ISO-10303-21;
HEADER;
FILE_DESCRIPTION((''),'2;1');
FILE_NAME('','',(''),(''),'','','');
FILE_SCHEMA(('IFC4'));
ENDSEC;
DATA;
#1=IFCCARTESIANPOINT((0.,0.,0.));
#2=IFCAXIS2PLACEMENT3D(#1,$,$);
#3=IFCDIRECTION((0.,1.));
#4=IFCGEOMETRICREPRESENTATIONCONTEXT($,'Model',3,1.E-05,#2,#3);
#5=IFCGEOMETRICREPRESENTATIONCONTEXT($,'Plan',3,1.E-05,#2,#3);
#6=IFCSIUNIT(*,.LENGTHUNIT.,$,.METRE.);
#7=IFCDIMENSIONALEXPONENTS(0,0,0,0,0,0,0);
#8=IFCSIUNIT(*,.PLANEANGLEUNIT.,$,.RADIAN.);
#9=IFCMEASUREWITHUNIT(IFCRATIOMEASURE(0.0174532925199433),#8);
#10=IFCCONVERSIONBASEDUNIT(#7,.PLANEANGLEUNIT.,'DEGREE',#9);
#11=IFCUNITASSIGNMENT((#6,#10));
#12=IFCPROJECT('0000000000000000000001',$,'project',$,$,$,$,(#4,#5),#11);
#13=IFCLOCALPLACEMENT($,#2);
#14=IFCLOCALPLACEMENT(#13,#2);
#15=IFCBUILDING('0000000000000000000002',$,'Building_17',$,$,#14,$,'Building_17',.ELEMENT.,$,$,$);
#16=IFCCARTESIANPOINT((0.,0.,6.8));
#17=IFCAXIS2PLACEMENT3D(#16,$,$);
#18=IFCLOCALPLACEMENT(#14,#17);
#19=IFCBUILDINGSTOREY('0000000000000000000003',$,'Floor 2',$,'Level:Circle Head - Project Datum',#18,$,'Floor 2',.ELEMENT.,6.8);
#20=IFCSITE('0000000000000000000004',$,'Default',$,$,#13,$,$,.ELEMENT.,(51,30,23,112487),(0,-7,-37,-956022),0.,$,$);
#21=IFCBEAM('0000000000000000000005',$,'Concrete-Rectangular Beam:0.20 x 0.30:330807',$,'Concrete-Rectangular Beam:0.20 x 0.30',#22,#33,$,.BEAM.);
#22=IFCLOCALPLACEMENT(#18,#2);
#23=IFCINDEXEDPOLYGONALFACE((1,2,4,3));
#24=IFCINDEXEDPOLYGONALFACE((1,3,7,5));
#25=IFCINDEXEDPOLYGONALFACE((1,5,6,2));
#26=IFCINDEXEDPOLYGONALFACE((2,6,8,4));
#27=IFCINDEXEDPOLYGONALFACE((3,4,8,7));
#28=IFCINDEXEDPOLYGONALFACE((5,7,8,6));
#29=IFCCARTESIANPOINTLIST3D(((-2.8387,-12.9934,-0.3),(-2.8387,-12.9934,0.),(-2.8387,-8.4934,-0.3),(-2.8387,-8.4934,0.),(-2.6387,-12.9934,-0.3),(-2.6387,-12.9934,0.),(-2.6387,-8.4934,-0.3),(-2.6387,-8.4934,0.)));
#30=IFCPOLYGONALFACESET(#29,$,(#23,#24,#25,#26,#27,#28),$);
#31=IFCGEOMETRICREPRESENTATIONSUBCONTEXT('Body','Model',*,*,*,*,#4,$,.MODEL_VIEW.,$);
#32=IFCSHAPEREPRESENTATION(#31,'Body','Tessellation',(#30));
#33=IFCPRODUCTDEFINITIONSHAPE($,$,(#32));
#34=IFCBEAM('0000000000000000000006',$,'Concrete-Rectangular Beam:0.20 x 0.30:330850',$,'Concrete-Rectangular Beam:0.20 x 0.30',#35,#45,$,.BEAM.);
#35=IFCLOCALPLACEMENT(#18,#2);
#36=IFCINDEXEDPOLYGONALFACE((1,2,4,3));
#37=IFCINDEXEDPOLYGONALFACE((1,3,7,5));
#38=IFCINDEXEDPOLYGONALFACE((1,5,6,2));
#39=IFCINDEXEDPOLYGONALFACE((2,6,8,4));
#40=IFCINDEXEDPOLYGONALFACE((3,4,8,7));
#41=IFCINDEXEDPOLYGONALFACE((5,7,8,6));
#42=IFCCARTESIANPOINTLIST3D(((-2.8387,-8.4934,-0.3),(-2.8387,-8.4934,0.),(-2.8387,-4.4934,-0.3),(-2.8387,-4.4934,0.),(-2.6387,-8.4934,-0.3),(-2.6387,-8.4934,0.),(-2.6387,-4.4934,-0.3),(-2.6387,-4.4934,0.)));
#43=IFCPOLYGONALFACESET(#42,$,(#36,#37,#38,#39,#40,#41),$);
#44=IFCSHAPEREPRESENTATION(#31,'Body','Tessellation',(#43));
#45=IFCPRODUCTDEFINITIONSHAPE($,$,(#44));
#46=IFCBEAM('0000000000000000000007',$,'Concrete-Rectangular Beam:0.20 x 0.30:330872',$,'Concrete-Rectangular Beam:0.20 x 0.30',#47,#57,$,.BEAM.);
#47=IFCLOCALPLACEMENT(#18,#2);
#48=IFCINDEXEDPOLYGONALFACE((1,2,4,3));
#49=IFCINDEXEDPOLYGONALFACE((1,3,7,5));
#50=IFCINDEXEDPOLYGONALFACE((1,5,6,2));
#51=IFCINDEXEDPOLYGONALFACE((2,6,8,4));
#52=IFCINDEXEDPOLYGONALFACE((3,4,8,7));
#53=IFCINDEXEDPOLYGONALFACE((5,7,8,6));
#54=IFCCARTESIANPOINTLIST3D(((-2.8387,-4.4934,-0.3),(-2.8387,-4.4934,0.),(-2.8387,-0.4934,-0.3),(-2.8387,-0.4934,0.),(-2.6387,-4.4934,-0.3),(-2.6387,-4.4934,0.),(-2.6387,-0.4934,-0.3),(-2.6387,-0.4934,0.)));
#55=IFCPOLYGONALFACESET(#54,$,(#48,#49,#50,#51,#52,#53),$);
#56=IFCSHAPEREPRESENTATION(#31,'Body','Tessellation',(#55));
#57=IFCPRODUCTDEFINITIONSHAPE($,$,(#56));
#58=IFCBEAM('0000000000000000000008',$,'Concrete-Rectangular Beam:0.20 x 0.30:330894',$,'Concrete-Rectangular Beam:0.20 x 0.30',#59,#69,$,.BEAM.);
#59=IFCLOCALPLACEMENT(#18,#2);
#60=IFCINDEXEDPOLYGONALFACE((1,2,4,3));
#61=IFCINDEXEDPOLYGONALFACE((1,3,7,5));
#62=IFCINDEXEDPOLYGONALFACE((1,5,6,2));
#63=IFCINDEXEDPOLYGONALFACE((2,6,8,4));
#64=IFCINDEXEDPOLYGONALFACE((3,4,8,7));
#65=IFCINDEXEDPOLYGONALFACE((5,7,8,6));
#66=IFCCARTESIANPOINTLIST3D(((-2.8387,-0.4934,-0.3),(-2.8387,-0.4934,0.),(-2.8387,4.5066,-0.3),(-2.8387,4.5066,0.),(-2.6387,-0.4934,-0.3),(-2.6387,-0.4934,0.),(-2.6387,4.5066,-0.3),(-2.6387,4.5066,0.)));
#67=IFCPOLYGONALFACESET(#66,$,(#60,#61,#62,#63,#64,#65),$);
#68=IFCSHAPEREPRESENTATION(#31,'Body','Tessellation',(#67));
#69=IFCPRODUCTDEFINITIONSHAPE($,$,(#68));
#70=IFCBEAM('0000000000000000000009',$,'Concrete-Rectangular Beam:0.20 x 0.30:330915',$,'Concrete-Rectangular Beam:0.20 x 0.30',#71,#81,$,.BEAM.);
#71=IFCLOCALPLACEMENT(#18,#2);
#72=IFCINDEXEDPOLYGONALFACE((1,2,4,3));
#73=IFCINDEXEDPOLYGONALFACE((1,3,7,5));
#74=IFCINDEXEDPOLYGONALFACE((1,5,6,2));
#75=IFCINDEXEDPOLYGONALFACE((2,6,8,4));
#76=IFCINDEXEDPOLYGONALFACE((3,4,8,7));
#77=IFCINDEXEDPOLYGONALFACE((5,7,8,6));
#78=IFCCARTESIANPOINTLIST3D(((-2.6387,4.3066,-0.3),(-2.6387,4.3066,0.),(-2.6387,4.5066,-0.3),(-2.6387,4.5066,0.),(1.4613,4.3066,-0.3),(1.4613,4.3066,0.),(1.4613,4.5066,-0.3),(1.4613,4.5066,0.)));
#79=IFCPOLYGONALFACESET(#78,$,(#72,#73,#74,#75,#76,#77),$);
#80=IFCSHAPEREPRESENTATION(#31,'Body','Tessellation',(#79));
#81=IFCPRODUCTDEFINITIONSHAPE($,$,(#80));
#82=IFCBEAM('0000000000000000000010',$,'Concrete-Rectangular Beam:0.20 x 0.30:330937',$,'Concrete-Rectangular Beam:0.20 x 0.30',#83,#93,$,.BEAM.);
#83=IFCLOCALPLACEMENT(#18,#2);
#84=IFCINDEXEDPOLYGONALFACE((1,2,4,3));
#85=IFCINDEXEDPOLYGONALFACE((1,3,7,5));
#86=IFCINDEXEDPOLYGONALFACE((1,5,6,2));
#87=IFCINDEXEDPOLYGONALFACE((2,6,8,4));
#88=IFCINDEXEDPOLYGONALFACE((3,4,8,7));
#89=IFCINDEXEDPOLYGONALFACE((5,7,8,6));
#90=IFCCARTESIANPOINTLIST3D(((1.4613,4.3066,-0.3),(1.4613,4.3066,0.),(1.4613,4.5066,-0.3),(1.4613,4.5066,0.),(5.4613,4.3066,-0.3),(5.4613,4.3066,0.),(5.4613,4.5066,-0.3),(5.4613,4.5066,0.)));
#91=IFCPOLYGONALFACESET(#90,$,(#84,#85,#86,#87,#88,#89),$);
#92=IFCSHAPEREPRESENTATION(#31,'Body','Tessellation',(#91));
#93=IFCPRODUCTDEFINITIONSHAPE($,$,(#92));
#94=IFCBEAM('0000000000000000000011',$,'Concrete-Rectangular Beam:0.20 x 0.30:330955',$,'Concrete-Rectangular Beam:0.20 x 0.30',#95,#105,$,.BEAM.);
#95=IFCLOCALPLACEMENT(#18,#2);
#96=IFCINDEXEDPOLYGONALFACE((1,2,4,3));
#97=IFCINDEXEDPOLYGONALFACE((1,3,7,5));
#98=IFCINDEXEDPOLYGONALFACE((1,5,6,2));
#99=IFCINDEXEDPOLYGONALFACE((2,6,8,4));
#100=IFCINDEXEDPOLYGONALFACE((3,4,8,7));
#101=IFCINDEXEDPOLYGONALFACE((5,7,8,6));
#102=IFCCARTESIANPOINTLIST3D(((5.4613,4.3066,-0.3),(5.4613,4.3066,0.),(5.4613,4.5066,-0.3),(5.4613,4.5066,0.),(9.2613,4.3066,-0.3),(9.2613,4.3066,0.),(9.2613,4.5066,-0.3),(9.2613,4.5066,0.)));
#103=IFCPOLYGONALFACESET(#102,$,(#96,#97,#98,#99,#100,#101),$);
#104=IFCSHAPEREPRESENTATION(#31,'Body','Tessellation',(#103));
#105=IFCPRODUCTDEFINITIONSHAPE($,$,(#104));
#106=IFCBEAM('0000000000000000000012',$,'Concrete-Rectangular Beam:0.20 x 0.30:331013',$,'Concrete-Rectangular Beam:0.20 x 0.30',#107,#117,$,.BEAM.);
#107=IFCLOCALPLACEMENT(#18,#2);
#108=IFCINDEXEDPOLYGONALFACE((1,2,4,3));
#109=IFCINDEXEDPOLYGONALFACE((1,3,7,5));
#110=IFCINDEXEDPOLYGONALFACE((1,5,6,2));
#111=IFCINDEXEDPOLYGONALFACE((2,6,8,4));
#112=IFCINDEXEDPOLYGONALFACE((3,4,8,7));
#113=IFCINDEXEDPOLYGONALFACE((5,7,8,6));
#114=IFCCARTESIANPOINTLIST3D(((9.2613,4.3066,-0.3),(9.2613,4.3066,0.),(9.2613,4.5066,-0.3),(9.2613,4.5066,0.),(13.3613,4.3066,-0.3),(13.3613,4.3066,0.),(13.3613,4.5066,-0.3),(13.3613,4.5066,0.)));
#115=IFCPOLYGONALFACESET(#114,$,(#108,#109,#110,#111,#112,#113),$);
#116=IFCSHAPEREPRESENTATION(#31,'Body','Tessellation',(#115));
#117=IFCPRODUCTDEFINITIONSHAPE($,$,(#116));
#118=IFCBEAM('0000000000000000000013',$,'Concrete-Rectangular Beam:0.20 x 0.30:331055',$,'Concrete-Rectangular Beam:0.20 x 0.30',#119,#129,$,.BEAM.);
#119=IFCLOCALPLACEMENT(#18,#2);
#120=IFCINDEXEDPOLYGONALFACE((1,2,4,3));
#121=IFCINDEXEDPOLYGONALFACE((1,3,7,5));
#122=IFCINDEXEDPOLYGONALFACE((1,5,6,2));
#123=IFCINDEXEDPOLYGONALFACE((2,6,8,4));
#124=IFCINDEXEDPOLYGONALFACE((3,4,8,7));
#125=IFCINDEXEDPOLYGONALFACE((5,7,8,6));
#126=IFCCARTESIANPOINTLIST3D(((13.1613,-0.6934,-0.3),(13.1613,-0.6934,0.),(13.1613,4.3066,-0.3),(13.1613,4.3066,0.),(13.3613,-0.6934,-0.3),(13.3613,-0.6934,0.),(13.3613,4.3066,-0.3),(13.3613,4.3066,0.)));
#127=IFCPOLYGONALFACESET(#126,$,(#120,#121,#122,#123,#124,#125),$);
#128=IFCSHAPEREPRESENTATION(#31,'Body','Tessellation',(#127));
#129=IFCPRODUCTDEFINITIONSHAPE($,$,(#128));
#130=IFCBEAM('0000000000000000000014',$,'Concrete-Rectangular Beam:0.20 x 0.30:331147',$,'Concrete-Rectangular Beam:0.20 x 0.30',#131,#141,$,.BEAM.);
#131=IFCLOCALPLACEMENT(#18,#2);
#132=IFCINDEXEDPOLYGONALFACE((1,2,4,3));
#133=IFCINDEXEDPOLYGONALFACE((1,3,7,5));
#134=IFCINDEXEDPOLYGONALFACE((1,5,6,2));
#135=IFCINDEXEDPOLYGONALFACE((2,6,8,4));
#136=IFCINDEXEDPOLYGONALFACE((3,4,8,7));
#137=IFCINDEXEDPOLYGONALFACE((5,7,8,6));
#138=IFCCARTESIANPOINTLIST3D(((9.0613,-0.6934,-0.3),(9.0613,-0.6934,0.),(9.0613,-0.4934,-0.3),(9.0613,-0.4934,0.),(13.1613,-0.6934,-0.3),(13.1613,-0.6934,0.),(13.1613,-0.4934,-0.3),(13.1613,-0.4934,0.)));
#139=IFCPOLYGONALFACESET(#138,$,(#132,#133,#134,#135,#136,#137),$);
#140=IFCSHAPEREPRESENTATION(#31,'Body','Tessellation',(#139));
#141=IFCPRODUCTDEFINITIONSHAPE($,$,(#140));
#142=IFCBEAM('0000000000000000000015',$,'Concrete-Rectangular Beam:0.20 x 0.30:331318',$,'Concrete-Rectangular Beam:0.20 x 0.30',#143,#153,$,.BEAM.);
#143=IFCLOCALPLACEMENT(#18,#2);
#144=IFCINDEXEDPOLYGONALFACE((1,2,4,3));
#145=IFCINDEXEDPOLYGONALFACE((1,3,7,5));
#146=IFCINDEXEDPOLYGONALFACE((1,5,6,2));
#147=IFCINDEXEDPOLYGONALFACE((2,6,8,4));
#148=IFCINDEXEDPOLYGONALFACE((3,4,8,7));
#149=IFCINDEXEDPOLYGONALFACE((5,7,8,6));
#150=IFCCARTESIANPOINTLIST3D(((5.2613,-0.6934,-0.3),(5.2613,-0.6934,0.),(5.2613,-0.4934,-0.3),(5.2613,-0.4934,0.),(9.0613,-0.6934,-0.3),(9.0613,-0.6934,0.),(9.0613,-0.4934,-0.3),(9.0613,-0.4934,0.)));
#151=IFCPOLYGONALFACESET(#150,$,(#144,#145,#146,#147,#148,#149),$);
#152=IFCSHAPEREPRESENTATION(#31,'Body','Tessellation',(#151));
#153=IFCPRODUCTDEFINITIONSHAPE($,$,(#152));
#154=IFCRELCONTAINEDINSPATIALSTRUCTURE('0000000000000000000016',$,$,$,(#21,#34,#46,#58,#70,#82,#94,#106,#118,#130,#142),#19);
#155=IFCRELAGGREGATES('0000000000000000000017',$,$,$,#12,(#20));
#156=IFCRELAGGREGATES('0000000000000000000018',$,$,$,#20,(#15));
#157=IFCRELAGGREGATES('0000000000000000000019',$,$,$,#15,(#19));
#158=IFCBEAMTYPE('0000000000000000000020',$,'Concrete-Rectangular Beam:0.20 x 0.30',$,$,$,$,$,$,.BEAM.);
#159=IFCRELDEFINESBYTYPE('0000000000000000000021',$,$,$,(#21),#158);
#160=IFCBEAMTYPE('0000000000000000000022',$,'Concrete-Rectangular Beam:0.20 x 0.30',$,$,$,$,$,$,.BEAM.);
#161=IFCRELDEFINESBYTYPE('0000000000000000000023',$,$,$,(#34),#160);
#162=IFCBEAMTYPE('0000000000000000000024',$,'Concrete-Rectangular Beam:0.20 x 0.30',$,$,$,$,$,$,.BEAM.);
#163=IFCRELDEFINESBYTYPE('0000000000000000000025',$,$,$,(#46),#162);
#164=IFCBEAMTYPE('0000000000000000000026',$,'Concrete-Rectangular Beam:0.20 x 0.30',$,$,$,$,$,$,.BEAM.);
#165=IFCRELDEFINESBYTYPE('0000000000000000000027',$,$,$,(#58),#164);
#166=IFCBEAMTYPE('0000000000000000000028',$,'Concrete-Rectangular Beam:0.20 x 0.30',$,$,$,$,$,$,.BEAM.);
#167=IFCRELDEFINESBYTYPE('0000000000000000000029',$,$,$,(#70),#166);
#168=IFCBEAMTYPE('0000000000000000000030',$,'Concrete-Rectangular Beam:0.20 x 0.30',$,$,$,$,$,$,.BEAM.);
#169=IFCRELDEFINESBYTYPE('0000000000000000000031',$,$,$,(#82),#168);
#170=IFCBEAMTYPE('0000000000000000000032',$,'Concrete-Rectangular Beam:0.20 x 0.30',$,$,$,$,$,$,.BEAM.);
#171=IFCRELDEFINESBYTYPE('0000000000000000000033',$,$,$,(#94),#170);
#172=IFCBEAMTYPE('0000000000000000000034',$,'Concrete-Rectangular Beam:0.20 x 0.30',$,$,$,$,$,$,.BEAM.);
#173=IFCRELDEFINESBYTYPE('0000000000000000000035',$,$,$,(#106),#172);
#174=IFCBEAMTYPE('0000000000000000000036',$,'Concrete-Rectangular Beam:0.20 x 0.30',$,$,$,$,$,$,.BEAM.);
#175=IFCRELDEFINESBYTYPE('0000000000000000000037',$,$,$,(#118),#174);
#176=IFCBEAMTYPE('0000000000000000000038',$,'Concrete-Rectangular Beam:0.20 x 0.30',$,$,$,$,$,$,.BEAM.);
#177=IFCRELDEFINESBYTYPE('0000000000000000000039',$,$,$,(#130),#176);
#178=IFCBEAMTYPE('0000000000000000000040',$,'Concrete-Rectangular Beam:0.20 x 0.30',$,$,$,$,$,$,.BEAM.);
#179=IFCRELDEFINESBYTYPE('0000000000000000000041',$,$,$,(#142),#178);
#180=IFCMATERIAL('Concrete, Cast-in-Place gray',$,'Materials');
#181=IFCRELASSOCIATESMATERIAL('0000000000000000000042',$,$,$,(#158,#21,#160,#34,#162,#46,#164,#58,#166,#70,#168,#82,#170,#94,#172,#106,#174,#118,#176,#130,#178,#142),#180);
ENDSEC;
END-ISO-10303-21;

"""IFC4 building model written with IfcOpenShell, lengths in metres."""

from ifc_helpers import new_model, entity, si_unit, converted_unit, direction, frame, origin, place, context, subcontext, project, spatial, indexed_curve, outline, extrude, source, transform, mapped, material, type_object, type_shapes, element, save


model = new_model("IFC4")

# Units and contexts
model_context = context("Model", 3, precision=1e-05, world=origin(), true_north=direction((0.0, 1.0)))
plan_context = context("Plan", 3, precision=1e-05, world=origin(), true_north=direction((0.0, 1.0)))
body_context = subcontext(model_context, "Body", "Model", "MODEL_VIEW")
ifc_project = project(units=[si_unit("LENGTHUNIT", "METRE"), converted_unit("PLANEANGLEUNIT", "DEGREE", entity("IfcRatioMeasure", 0.0174532925199433), si_unit("PLANEANGLEUNIT", "RADIAN"), dimensions=[0, 0, 0, 0, 0, 0, 0])], contexts=[model_context, plan_context])

# Site, building, storey
site_placement = place(None, origin())
site = spatial("IfcSite", under=ifc_project, at=site_placement, Name="Default", CompositionType="ELEMENT", RefLatitude=(51, 30, 23, 112487), RefLongitude=(0, -7, -37, -956022), RefElevation=0.0)
building_placement = place(site_placement, origin())
building = spatial("IfcBuilding", under=site, at=building_placement, Name="Building_17", LongName="Building_17", CompositionType="ELEMENT")
storey_placement = place(building_placement, frame((0.0, 0.0, 6.8)))
storey = spatial("IfcBuildingStorey", under=building, at=storey_placement, Name="Floor 2", ObjectType="Level:Circle Head - Project Datum", LongName="Floor 2", CompositionType="ELEMENT", Elevation=6.8)

# Beams
ifc_material = material(Name="Concrete, Cast-in-Place gray", Category="Materials")
beam_type_1 = type_object("IfcBeamType", Name="Concrete-Rectangular Beam:0.20 x 0.30", PredefinedType="BEAM", material=ifc_material)
shared_shape_1 = source(origin(), body_context, "Body", "SweptSolid", [
    extrude(outline(indexed_curve([(-0.1, -0.15), (0.1, -0.15), (0.1, 0.15), (-0.1, 0.15), (-0.1, -0.15)], self_intersect=False)), frame((-2.7387, -12.9934, 6.65), z_axis=(0.0, 1.0, 0.0), x_axis=(-1.0, 0.0, 0.0)), (0.0, 0.0, 1.0), 4.5),
])
type_shapes(beam_type_1, [shared_shape_1])
beam_1_placement = place(storey_placement, frame((0.0, 0.0, -6.8)))
element("IfcBeam", 1, at=beam_1_placement, inside=storey, type_object=beam_type_1, material=ifc_material, Name="Concrete-Rectangular Beam:0.20 x 0.30:330807", ObjectType="Concrete-Rectangular Beam:0.20 x 0.30", PredefinedType="BEAM", context=body_context, shape_type="MappedRepresentation", body=[
    mapped(shared_shape_1, transform((0.0, 0.0, 0.0), scale=1.0)),
])
beam_type_2 = type_object("IfcBeamType", Name="Concrete-Rectangular Beam:0.20 x 0.30", PredefinedType="BEAM", material=ifc_material)
shared_shape_2 = source(origin(), body_context, "Body", "SweptSolid", [
    extrude(outline(indexed_curve([(-0.1, -0.15), (0.1, -0.15), (0.1, 0.15), (-0.1, 0.15), (-0.1, -0.15)], self_intersect=False)), frame((-2.7387, -8.4934, 6.65), z_axis=(0.0, 1.0, 0.0), x_axis=(-1.0, 0.0, 0.0)), (0.0, 0.0, 1.0), 4.0),
])
type_shapes(beam_type_2, [shared_shape_2])
beam_2_placement = place(storey_placement, frame((0.0, 0.0, -6.8)))
element("IfcBeam", 2, at=beam_2_placement, inside=storey, type_object=beam_type_2, material=ifc_material, Name="Concrete-Rectangular Beam:0.20 x 0.30:330850", ObjectType="Concrete-Rectangular Beam:0.20 x 0.30", PredefinedType="BEAM", context=body_context, shape_type="MappedRepresentation", body=[
    mapped(shared_shape_2, transform((0.0, 0.0, 0.0), scale=1.0)),
])
beam_type_3 = type_object("IfcBeamType", Name="Concrete-Rectangular Beam:0.20 x 0.30", PredefinedType="BEAM", material=ifc_material)
shared_shape_3 = source(origin(), body_context, "Body", "SweptSolid", [
    extrude(outline(indexed_curve([(-0.1, -0.15), (0.1, -0.15), (0.1, 0.15), (-0.1, 0.15), (-0.1, -0.15)], self_intersect=False)), frame((-2.7387, -4.4934, 6.65), z_axis=(0.0, 1.0, 0.0), x_axis=(-1.0, 0.0, 0.0)), (0.0, 0.0, 1.0), 4.0),
])
type_shapes(beam_type_3, [shared_shape_3])
beam_3_placement = place(storey_placement, frame((0.0, 0.0, -6.8)))
element("IfcBeam", 3, at=beam_3_placement, inside=storey, type_object=beam_type_3, material=ifc_material, Name="Concrete-Rectangular Beam:0.20 x 0.30:330872", ObjectType="Concrete-Rectangular Beam:0.20 x 0.30", PredefinedType="BEAM", context=body_context, shape_type="MappedRepresentation", body=[
    mapped(shared_shape_3, transform((0.0, 0.0, 0.0), scale=1.0)),
])
beam_type_4 = type_object("IfcBeamType", Name="Concrete-Rectangular Beam:0.20 x 0.30", PredefinedType="BEAM", material=ifc_material)
shared_shape_4 = source(origin(), body_context, "Body", "SweptSolid", [
    extrude(outline(indexed_curve([(-0.1, -0.15), (0.1, -0.15), (0.1, 0.15), (-0.1, 0.15), (-0.1, -0.15)], self_intersect=False)), frame((-2.7387, -0.4934, 6.65), z_axis=(0.0, 1.0, 0.0), x_axis=(-1.0, 0.0, 0.0)), (0.0, 0.0, 1.0), 5.0),
])
type_shapes(beam_type_4, [shared_shape_4])
beam_4_placement = place(storey_placement, frame((0.0, 0.0, -6.8)))
element("IfcBeam", 4, at=beam_4_placement, inside=storey, type_object=beam_type_4, material=ifc_material, Name="Concrete-Rectangular Beam:0.20 x 0.30:330894", ObjectType="Concrete-Rectangular Beam:0.20 x 0.30", PredefinedType="BEAM", context=body_context, shape_type="MappedRepresentation", body=[
    mapped(shared_shape_4, transform((0.0, 0.0, 0.0), scale=1.0)),
])
beam_type_5 = type_object("IfcBeamType", Name="Concrete-Rectangular Beam:0.20 x 0.30", PredefinedType="BEAM", material=ifc_material)
shared_shape_5 = source(origin(), body_context, "Body", "SweptSolid", [
    extrude(outline(indexed_curve([(-0.15, -0.1), (0.15, -0.1), (0.15, 0.1), (-0.15, 0.1), (-0.15, -0.1)], self_intersect=False)), frame((-2.6387, 4.4066, 6.65), z_axis=(1.0, 0.0, 0.0), x_axis=(0.0, 0.0, -1.0)), (0.0, 0.0, 1.0), 4.1),
])
type_shapes(beam_type_5, [shared_shape_5])
beam_5_placement = place(storey_placement, frame((0.0, 0.0, -6.8)))
element("IfcBeam", 5, at=beam_5_placement, inside=storey, type_object=beam_type_5, material=ifc_material, Name="Concrete-Rectangular Beam:0.20 x 0.30:330915", ObjectType="Concrete-Rectangular Beam:0.20 x 0.30", PredefinedType="BEAM", context=body_context, shape_type="MappedRepresentation", body=[
    mapped(shared_shape_5, transform((0.0, 0.0, 0.0), scale=1.0)),
])
beam_type_6 = type_object("IfcBeamType", Name="Concrete-Rectangular Beam:0.20 x 0.30", PredefinedType="BEAM", material=ifc_material)
shared_shape_6 = source(origin(), body_context, "Body", "SweptSolid", [
    extrude(outline(indexed_curve([(-0.15, -0.1), (0.15, -0.1), (0.15, 0.1), (-0.15, 0.1), (-0.15, -0.1)], self_intersect=False)), frame((1.4613, 4.4066, 6.65), z_axis=(1.0, 0.0, 0.0), x_axis=(0.0, 0.0, -1.0)), (0.0, 0.0, 1.0), 4.0),
])
type_shapes(beam_type_6, [shared_shape_6])
beam_6_placement = place(storey_placement, frame((0.0, 0.0, -6.8)))
element("IfcBeam", 6, at=beam_6_placement, inside=storey, type_object=beam_type_6, material=ifc_material, Name="Concrete-Rectangular Beam:0.20 x 0.30:330937", ObjectType="Concrete-Rectangular Beam:0.20 x 0.30", PredefinedType="BEAM", context=body_context, shape_type="MappedRepresentation", body=[
    mapped(shared_shape_6, transform((0.0, 0.0, 0.0), scale=1.0)),
])
beam_type_7 = type_object("IfcBeamType", Name="Concrete-Rectangular Beam:0.20 x 0.30", PredefinedType="BEAM", material=ifc_material)
shared_shape_7 = source(origin(), body_context, "Body", "SweptSolid", [
    extrude(outline(indexed_curve([(-0.15, -0.1), (0.15, -0.1), (0.15, 0.1), (-0.15, 0.1), (-0.15, -0.1)], self_intersect=False)), frame((5.4613, 4.4066, 6.65), z_axis=(1.0, 0.0, 0.0), x_axis=(0.0, 0.0, -1.0)), (0.0, 0.0, 1.0), 3.8),
])
type_shapes(beam_type_7, [shared_shape_7])
beam_7_placement = place(storey_placement, frame((0.0, 0.0, -6.8)))
element("IfcBeam", 7, at=beam_7_placement, inside=storey, type_object=beam_type_7, material=ifc_material, Name="Concrete-Rectangular Beam:0.20 x 0.30:330955", ObjectType="Concrete-Rectangular Beam:0.20 x 0.30", PredefinedType="BEAM", context=body_context, shape_type="MappedRepresentation", body=[
    mapped(shared_shape_7, transform((0.0, 0.0, 0.0), scale=1.0)),
])
beam_type_8 = type_object("IfcBeamType", Name="Concrete-Rectangular Beam:0.20 x 0.30", PredefinedType="BEAM", material=ifc_material)
shared_shape_8 = source(origin(), body_context, "Body", "SweptSolid", [
    extrude(outline(indexed_curve([(-0.15, -0.1), (0.15, -0.1), (0.15, 0.1), (-0.15, 0.1), (-0.15, -0.1)], self_intersect=False)), frame((9.2613, 4.4066, 6.65), z_axis=(1.0, 0.0, 0.0), x_axis=(0.0, 0.0, -1.0)), (0.0, 0.0, 1.0), 4.1),
])
type_shapes(beam_type_8, [shared_shape_8])
beam_8_placement = place(storey_placement, frame((0.0, 0.0, -6.8)))
element("IfcBeam", 8, at=beam_8_placement, inside=storey, type_object=beam_type_8, material=ifc_material, Name="Concrete-Rectangular Beam:0.20 x 0.30:331013", ObjectType="Concrete-Rectangular Beam:0.20 x 0.30", PredefinedType="BEAM", context=body_context, shape_type="MappedRepresentation", body=[
    mapped(shared_shape_8, transform((0.0, 0.0, 0.0), scale=1.0)),
])
beam_type_9 = type_object("IfcBeamType", Name="Concrete-Rectangular Beam:0.20 x 0.30", PredefinedType="BEAM", material=ifc_material)
shared_shape_9 = source(origin(), body_context, "Body", "SweptSolid", [
    extrude(outline(indexed_curve([(-0.1, -0.15), (0.1, -0.15), (0.1, 0.15), (-0.1, 0.15), (-0.1, -0.15)], self_intersect=False)), frame((13.2613, 4.3066, 6.65), z_axis=(0.0, -1.0, 0.0), x_axis=(-1.0, 0.0, 0.0)), (0.0, 0.0, 1.0), 5.0),
])
type_shapes(beam_type_9, [shared_shape_9])
beam_9_placement = place(storey_placement, frame((0.0, 0.0, -6.8)))
element("IfcBeam", 9, at=beam_9_placement, inside=storey, type_object=beam_type_9, material=ifc_material, Name="Concrete-Rectangular Beam:0.20 x 0.30:331055", ObjectType="Concrete-Rectangular Beam:0.20 x 0.30", PredefinedType="BEAM", context=body_context, shape_type="MappedRepresentation", body=[
    mapped(shared_shape_9, transform((0.0, 0.0, 0.0), scale=1.0)),
])
beam_type_10 = type_object("IfcBeamType", Name="Concrete-Rectangular Beam:0.20 x 0.30", PredefinedType="BEAM", material=ifc_material)
shared_shape_10 = source(origin(), body_context, "Body", "SweptSolid", [
    extrude(outline(indexed_curve([(-0.15, -0.1), (0.15, -0.1), (0.15, 0.1), (-0.15, 0.1), (-0.15, -0.1)], self_intersect=False)), frame((13.1613, -0.5934, 6.65), z_axis=(-1.0, 0.0, 0.0), x_axis=(0.0, 0.0, -1.0)), (0.0, 0.0, 1.0), 4.1),
])
type_shapes(beam_type_10, [shared_shape_10])
beam_10_placement = place(storey_placement, frame((0.0, 0.0, -6.8)))
element("IfcBeam", 10, at=beam_10_placement, inside=storey, type_object=beam_type_10, material=ifc_material, Name="Concrete-Rectangular Beam:0.20 x 0.30:331147", ObjectType="Concrete-Rectangular Beam:0.20 x 0.30", PredefinedType="BEAM", context=body_context, shape_type="MappedRepresentation", body=[
    mapped(shared_shape_10, transform((0.0, 0.0, 0.0), scale=1.0)),
])
beam_type_11 = type_object("IfcBeamType", Name="Concrete-Rectangular Beam:0.20 x 0.30", PredefinedType="BEAM", material=ifc_material)
shared_shape_11 = source(origin(), body_context, "Body", "SweptSolid", [
    extrude(outline(indexed_curve([(-0.15, -0.1), (0.15, -0.1), (0.15, 0.1), (-0.15, 0.1), (-0.15, -0.1)], self_intersect=False)), frame((9.0613, -0.5934, 6.65), z_axis=(-1.0, 0.0, 0.0), x_axis=(0.0, 0.0, -1.0)), (0.0, 0.0, 1.0), 3.8),
])
type_shapes(beam_type_11, [shared_shape_11])
beam_11_placement = place(storey_placement, frame((0.0, 0.0, -6.8)))
element("IfcBeam", 11, at=beam_11_placement, inside=storey, type_object=beam_type_11, material=ifc_material, Name="Concrete-Rectangular Beam:0.20 x 0.30:331318", ObjectType="Concrete-Rectangular Beam:0.20 x 0.30", PredefinedType="BEAM", context=body_context, shape_type="MappedRepresentation", body=[
    mapped(shared_shape_11, transform((0.0, 0.0, 0.0), scale=1.0)),
])

save(model, "model.ifc")
